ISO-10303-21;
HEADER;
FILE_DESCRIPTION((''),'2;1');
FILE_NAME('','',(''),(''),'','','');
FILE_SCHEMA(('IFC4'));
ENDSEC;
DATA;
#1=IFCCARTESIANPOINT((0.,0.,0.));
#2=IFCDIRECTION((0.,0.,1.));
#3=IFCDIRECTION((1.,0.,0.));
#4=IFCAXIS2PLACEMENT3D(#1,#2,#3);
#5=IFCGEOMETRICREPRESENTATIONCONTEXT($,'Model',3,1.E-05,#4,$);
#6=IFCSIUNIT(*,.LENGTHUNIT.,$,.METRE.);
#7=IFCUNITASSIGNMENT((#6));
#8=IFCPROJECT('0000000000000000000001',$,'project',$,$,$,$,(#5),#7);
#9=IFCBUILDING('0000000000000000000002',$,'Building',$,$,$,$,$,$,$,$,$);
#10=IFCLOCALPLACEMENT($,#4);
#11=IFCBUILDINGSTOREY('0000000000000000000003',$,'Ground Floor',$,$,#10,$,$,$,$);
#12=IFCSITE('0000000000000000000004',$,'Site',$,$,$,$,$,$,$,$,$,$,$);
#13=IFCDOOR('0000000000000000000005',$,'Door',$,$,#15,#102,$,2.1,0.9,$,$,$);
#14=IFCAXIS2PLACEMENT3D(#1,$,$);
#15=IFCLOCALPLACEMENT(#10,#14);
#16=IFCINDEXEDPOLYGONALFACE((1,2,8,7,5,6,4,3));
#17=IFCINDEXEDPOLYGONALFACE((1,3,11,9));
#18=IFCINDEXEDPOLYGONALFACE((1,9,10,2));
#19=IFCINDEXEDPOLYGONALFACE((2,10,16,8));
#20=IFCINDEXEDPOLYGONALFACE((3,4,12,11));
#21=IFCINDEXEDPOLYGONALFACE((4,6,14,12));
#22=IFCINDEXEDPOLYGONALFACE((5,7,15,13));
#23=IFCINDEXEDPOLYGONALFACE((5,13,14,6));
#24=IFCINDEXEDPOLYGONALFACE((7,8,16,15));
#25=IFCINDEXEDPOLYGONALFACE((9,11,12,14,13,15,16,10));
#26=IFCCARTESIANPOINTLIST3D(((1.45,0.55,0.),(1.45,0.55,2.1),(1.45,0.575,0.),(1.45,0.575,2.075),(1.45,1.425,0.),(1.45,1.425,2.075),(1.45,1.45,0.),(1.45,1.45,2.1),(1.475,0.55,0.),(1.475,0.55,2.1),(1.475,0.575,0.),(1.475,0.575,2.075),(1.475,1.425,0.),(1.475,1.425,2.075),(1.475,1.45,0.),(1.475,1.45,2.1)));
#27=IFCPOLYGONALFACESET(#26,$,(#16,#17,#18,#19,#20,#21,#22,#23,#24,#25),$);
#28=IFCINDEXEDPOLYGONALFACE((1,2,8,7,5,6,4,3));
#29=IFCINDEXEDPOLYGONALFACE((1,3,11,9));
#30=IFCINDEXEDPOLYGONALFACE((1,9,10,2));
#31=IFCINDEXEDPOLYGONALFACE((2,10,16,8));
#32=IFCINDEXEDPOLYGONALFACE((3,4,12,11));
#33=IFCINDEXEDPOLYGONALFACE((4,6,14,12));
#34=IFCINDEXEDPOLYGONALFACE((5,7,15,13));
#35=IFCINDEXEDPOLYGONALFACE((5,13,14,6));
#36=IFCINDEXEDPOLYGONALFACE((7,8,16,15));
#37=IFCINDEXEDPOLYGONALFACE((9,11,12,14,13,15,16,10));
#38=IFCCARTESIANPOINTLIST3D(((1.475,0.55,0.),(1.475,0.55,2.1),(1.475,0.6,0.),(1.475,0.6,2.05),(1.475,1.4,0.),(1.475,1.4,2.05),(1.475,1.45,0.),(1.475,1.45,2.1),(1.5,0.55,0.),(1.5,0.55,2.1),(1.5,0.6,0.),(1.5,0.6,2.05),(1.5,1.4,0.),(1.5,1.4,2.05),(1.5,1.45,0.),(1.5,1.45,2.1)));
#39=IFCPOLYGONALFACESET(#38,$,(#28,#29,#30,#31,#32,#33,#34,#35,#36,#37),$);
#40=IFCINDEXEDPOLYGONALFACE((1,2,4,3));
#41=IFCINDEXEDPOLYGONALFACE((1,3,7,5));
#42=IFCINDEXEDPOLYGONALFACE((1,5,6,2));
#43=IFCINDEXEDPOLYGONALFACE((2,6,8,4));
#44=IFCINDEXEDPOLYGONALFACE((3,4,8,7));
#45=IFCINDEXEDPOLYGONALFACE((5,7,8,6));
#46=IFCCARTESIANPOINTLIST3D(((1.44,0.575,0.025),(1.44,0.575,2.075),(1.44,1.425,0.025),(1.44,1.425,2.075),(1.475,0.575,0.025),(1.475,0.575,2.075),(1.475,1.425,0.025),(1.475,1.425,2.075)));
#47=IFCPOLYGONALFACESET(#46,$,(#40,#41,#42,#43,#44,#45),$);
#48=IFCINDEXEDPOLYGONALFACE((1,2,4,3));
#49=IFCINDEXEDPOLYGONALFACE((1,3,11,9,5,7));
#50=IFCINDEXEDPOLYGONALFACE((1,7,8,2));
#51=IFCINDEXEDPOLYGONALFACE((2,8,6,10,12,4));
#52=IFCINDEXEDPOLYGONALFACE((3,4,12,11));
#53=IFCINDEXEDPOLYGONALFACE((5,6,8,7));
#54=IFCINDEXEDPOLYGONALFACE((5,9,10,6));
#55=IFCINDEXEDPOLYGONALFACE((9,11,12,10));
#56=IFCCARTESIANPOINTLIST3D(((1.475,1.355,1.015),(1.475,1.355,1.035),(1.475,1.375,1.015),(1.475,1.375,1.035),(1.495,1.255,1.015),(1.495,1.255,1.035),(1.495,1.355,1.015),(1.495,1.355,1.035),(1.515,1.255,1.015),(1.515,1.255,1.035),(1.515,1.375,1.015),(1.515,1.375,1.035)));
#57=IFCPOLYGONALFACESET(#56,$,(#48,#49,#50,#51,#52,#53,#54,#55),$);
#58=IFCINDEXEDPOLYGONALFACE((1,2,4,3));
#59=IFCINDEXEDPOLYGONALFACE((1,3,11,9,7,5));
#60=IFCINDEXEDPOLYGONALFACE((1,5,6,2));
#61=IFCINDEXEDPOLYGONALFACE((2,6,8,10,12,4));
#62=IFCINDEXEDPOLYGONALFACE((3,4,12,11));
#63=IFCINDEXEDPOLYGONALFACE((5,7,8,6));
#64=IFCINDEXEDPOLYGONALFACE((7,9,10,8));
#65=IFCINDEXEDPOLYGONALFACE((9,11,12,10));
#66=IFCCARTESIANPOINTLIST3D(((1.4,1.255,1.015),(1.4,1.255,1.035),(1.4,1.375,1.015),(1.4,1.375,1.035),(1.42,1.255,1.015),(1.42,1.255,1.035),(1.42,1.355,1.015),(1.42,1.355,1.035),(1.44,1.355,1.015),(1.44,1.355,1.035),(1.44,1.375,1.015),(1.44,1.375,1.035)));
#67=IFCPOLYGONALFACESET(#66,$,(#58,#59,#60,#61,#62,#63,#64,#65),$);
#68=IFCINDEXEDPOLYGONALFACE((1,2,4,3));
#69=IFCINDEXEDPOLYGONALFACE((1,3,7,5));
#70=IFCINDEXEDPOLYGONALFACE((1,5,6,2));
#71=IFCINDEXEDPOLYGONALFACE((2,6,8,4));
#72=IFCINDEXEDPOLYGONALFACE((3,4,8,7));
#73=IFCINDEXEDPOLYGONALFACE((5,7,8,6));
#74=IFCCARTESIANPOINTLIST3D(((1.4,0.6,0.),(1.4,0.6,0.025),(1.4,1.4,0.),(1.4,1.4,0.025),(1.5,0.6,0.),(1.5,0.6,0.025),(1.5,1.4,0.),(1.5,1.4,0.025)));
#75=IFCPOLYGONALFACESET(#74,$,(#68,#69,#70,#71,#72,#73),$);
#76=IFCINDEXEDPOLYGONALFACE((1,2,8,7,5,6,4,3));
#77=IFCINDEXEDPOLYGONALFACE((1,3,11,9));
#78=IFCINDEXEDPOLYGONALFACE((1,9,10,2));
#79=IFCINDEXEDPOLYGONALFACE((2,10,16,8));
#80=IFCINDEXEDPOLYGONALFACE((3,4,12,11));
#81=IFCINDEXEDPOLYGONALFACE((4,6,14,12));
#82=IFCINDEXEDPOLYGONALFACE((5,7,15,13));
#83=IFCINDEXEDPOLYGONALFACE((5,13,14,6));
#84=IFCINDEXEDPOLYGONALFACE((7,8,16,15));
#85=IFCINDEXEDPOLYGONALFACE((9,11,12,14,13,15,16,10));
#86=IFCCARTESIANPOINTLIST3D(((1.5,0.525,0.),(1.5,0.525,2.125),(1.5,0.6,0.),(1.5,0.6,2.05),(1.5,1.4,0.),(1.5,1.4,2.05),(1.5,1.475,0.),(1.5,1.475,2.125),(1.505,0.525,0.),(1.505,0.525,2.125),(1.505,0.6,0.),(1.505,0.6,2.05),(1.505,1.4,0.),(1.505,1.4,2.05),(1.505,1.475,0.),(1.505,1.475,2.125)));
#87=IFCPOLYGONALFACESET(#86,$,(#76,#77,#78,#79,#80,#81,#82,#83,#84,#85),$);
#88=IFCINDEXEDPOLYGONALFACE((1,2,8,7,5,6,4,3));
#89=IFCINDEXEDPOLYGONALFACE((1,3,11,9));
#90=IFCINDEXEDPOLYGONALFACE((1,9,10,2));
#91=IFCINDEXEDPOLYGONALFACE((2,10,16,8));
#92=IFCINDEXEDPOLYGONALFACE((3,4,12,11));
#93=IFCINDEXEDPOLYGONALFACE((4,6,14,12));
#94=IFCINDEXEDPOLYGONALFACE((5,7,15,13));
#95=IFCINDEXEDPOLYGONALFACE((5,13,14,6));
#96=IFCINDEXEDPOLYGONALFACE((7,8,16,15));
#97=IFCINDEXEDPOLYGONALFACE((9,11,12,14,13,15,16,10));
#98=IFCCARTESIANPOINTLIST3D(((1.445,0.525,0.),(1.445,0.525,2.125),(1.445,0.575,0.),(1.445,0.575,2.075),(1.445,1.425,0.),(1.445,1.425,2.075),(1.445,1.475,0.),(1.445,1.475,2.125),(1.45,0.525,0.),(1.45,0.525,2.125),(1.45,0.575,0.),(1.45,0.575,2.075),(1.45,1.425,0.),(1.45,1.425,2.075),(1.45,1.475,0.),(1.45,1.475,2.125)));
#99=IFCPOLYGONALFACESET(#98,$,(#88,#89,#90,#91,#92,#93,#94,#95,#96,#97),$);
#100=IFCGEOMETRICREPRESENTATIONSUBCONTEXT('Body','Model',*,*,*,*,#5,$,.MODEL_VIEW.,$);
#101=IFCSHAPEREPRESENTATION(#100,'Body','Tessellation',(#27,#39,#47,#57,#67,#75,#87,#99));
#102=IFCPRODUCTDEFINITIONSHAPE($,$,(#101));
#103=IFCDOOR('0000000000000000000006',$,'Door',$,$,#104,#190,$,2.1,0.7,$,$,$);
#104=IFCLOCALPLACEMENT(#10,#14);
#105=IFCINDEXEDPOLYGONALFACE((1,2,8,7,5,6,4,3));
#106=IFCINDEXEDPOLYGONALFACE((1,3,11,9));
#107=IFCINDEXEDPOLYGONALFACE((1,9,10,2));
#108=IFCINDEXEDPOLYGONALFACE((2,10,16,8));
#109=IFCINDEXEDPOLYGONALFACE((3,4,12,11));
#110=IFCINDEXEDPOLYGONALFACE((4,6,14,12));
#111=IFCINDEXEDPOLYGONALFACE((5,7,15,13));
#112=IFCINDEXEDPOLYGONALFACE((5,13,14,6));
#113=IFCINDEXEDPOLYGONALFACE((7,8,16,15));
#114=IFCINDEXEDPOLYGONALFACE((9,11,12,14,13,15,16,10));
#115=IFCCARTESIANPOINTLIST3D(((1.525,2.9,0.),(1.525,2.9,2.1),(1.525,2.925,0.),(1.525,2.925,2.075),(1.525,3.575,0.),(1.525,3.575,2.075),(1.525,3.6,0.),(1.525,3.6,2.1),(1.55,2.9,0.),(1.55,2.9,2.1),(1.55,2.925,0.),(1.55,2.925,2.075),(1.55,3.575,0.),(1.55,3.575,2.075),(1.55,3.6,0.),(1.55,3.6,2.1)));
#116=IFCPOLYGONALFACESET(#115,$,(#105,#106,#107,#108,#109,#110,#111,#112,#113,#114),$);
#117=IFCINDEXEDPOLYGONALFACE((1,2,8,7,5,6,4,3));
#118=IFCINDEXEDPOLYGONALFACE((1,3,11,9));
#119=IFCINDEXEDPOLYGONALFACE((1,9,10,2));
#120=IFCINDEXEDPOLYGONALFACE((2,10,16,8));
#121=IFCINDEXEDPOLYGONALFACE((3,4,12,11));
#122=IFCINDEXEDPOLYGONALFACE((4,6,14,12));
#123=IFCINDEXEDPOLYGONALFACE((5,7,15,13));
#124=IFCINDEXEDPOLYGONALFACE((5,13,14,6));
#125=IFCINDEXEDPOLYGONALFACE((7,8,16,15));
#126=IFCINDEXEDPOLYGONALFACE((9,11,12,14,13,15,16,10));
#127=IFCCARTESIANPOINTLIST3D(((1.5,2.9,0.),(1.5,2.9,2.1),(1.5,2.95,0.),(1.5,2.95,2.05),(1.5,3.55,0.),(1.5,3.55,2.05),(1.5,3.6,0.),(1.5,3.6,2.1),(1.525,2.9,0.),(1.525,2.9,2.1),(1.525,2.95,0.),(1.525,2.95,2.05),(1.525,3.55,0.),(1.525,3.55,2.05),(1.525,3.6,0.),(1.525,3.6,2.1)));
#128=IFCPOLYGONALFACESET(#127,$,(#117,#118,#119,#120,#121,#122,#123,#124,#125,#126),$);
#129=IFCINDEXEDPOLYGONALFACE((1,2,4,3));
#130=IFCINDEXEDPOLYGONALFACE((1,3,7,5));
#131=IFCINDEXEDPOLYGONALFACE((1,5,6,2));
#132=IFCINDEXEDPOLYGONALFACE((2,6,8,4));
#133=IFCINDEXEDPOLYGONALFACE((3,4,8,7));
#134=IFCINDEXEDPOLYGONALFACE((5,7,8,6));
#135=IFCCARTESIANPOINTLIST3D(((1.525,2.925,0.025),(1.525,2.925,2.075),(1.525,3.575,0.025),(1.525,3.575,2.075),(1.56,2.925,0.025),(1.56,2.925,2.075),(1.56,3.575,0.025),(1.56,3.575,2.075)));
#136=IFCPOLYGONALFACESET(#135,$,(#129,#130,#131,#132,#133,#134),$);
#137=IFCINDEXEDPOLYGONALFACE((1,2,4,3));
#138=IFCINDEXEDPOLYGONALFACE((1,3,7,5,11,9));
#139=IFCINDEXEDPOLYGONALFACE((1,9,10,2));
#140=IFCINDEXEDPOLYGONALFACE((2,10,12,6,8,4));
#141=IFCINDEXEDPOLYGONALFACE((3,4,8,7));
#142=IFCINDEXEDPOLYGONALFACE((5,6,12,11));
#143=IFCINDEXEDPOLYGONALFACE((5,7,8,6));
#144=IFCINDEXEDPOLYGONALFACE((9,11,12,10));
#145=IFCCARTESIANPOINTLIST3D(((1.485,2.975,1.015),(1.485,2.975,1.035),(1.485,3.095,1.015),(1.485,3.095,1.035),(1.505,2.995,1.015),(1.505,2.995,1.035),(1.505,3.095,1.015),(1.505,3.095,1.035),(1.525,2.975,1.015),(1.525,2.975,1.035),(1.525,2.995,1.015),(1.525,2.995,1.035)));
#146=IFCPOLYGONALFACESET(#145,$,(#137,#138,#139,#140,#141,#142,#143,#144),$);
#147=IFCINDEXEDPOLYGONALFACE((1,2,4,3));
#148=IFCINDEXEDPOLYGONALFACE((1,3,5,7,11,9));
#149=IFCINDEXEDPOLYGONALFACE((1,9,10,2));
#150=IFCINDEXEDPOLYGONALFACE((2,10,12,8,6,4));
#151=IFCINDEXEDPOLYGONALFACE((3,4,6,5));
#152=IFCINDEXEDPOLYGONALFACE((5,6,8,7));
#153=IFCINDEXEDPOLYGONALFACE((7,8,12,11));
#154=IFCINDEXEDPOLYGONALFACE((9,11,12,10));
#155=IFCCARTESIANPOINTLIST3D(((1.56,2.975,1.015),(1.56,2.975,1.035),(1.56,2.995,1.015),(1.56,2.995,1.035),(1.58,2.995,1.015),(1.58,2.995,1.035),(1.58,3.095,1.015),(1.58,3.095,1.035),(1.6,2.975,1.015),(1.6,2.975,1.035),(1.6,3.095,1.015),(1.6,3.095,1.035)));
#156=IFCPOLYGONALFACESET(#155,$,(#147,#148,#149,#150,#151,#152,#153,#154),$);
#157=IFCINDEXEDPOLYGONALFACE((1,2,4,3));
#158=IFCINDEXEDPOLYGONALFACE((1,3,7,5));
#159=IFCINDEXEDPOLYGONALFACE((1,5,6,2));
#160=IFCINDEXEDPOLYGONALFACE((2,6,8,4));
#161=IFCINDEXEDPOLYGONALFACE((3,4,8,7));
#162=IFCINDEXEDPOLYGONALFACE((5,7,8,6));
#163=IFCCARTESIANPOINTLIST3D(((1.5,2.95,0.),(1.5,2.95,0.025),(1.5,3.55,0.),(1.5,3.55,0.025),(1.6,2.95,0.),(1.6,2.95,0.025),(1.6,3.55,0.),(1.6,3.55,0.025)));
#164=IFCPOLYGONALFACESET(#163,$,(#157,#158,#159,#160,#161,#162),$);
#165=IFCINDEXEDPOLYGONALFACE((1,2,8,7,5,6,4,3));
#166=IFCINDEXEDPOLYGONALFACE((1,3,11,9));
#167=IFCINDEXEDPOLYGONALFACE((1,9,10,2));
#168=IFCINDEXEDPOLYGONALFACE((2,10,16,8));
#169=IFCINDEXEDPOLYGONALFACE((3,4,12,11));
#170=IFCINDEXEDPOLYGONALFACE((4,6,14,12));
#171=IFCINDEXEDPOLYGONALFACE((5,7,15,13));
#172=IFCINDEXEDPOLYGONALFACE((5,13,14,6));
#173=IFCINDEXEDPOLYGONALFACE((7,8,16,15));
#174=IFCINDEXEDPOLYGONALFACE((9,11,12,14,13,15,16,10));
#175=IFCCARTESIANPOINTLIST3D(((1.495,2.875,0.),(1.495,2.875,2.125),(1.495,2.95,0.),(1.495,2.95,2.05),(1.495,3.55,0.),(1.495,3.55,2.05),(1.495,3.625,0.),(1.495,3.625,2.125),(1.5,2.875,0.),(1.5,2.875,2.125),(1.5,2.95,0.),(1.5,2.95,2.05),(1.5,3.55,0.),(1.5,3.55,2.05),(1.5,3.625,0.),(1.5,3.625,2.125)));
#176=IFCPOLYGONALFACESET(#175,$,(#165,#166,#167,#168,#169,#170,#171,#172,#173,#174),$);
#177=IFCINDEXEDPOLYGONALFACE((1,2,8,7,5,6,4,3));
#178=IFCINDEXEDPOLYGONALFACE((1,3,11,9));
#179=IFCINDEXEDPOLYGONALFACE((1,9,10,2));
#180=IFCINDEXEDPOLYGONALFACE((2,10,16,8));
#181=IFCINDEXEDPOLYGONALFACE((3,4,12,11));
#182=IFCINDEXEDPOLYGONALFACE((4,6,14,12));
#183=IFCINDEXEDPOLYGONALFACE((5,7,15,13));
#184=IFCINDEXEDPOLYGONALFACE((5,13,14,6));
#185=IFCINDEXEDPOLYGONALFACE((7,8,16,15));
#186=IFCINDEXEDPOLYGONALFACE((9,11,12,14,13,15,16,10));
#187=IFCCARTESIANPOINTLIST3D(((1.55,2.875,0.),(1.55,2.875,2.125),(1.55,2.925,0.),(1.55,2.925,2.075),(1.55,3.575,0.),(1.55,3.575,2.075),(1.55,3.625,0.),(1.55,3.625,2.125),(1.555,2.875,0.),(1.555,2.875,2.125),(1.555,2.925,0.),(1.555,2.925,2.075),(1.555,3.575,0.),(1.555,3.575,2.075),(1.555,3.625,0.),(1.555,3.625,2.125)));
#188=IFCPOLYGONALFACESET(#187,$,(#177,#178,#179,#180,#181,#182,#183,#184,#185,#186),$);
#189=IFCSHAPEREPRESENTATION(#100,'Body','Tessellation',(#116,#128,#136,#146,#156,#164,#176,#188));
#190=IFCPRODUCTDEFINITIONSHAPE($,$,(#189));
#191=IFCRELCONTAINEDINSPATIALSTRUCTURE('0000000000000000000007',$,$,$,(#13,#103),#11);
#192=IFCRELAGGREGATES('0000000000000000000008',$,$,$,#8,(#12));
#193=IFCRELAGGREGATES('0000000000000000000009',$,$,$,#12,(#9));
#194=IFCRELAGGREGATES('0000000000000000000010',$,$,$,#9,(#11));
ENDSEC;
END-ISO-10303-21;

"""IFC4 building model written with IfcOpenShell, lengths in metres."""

from ifc_helpers import new_model, si_unit, frame, origin_with_axes, place, context, subcontext, project, spatial, line, indexed_curve, outline, extrude, element, save


model = new_model("IFC4")

# Units and contexts
model_context = context("Model", 3, precision=1e-05, world=origin_with_axes())
body_context = subcontext(model_context, "Body", "Model", "MODEL_VIEW")
ifc_project = project(units=[si_unit("LENGTHUNIT", "METRE")], contexts=[model_context])

# Site, building, storey
site = spatial("IfcSite", under=ifc_project, Name="Site")
building = spatial("IfcBuilding", under=site, Name="Building")
storey_placement = place(None, origin_with_axes())
storey = spatial("IfcBuildingStorey", under=building, at=storey_placement, Name="Ground Floor")

# Doors
door_1_placement = place(storey_placement, frame((1.5, 0.55, 0.0), z_axis=(0.0, 0.0, 1.0), x_axis=(0.0, 1.0, 0.0)))
element("IfcDoor", 1, at=door_1_placement, inside=storey, Name="Door", OverallHeight=2.1, OverallWidth=0.9, context=body_context, shape_type="SweptSolid", body=[
    extrude(outline(indexed_curve([(0.0, 0.0), (0.0, 2.1), (0.9, 2.1), (0.9, 0.0), (0.875, 0.0), (0.875, 2.075), (0.025, 2.075), (0.025, 0.0)], segments=[line(1, 2, 3, 4, 5, 6, 7, 8, 1)])), frame((0.0, 0.025, 0.0), z_axis=(0.0, -1.0, 0.0), x_axis=(1.0, 0.0, 0.0)), (0.0, 0.0, -1.0), 0.025),
    extrude(outline(indexed_curve([(0.0, 0.0), (0.0, 2.1), (0.9, 2.1), (0.9, 0.0), (0.85, 0.0), (0.85, 2.05), (0.05, 2.05), (0.05, 0.0)], segments=[line(1, 2, 3, 4, 5, 6, 7, 8, 1)])), frame((0.0, 0.0, 0.0), z_axis=(0.0, -1.0, 0.0), x_axis=(1.0, 0.0, 0.0)), (0.0, 0.0, -1.0), 0.025),
    extrude(outline(indexed_curve([(0.0, 0.0), (0.85, 0.0), (0.85, 0.035), (0.0, 0.035)], segments=[line(1, 2, 3, 4, 1)])), frame((0.025, 0.025, 0.025), z_axis=(0.0, 0.0, 1.0), x_axis=(1.0, 0.0, 0.0)), (0.0, 0.0, 1.0), 2.05),
    extrude(outline(indexed_curve([(0.0, 0.0), (0.0, -0.04), (-0.12, -0.04), (-0.12, -0.02), (-0.02, -0.02), (-0.02, 0.0)], segments=[line(1, 2, 3, 4, 5, 6, 1)])), frame((0.825, 0.025, 1.015), z_axis=(0.0, 0.0, 1.0), x_axis=(1.0, 0.0, 0.0)), (0.0, 0.0, 1.0), 0.02),
    extrude(outline(indexed_curve([(0.0, 0.0), (0.0, 0.04), (-0.12, 0.04), (-0.12, 0.02), (-0.02, 0.02), (-0.02, 0.0)], segments=[line(1, 2, 3, 4, 5, 6, 1)])), frame((0.825, 0.06, 1.015), z_axis=(0.0, 0.0, 1.0), x_axis=(1.0, 0.0, 0.0)), (0.0, 0.0, 1.0), 0.02),
    extrude(outline(indexed_curve([(0.0, 0.0), (0.8, 0.0), (0.8, 0.1), (0.0, 0.1)], segments=[line(1, 2, 3, 4, 1)])), frame((0.05, 0.0, 0.0), z_axis=(0.0, 0.0, 1.0), x_axis=(1.0, 0.0, 0.0)), (0.0, 0.0, 1.0), 0.025),
    extrude(outline(indexed_curve([(0.0, 0.0), (0.0, 2.125), (0.95, 2.125), (0.95, 0.0), (0.875, 0.0), (0.875, 2.05), (0.075, 2.05), (0.075, 0.0)], segments=[line(1, 2, 3, 4, 5, 6, 7, 8, 1)])), frame((-0.025, -0.005, 0.0), z_axis=(0.0, -1.0, 0.0), x_axis=(1.0, 0.0, 0.0)), (0.0, 0.0, -1.0), 0.005),
    extrude(outline(indexed_curve([(0.0, 0.0), (0.0, 2.125), (0.95, 2.125), (0.95, 0.0), (0.9, 0.0), (0.9, 2.075), (0.05, 2.075), (0.05, 0.0)], segments=[line(1, 2, 3, 4, 5, 6, 7, 8, 1)])), frame((-0.025, 0.05, 0.0), z_axis=(0.0, -1.0, 0.0), x_axis=(1.0, 0.0, 0.0)), (0.0, 0.0, -1.0), 0.005),
])
door_2_placement = place(storey_placement, frame((1.5, 3.6, 0.0), z_axis=(0.0, 0.0, 1.0), x_axis=(0.0, -1.0, 0.0)))
element("IfcDoor", 2, at=door_2_placement, inside=storey, Name="Door", OverallHeight=2.1, OverallWidth=0.7, context=body_context, shape_type="SweptSolid", body=[
    extrude(outline(indexed_curve([(0.0, 0.0), (0.0, 2.1), (0.7, 2.1), (0.7, 0.0), (0.675, 0.0), (0.675, 2.075), (0.025, 2.075), (0.025, 0.0)], segments=[line(1, 2, 3, 4, 5, 6, 7, 8, 1)])), frame((0.0, 0.025, 0.0), z_axis=(0.0, -1.0, 0.0), x_axis=(1.0, 0.0, 0.0)), (0.0, 0.0, -1.0), 0.025),
    extrude(outline(indexed_curve([(0.0, 0.0), (0.0, 2.1), (0.7, 2.1), (0.7, 0.0), (0.65, 0.0), (0.65, 2.05), (0.05, 2.05), (0.05, 0.0)], segments=[line(1, 2, 3, 4, 5, 6, 7, 8, 1)])), frame((0.0, 0.0, 0.0), z_axis=(0.0, -1.0, 0.0), x_axis=(1.0, 0.0, 0.0)), (0.0, 0.0, -1.0), 0.025),
    extrude(outline(indexed_curve([(0.0, 0.0), (0.65, 0.0), (0.65, 0.035), (0.0, 0.035)], segments=[line(1, 2, 3, 4, 1)])), frame((0.025, 0.025, 0.025), z_axis=(0.0, 0.0, 1.0), x_axis=(1.0, 0.0, 0.0)), (0.0, 0.0, 1.0), 2.05),
    extrude(outline(indexed_curve([(0.0, 0.0), (0.0, -0.04), (-0.12, -0.04), (-0.12, -0.02), (-0.02, -0.02), (-0.02, 0.0)], segments=[line(1, 2, 3, 4, 5, 6, 1)])), frame((0.625, 0.025, 1.015), z_axis=(0.0, 0.0, 1.0), x_axis=(1.0, 0.0, 0.0)), (0.0, 0.0, 1.0), 0.02),
    extrude(outline(indexed_curve([(0.0, 0.0), (0.0, 0.04), (-0.12, 0.04), (-0.12, 0.02), (-0.02, 0.02), (-0.02, 0.0)], segments=[line(1, 2, 3, 4, 5, 6, 1)])), frame((0.625, 0.06, 1.015), z_axis=(0.0, 0.0, 1.0), x_axis=(1.0, 0.0, 0.0)), (0.0, 0.0, 1.0), 0.02),
    extrude(outline(indexed_curve([(0.0, 0.0), (0.6, 0.0), (0.6, 0.1), (0.0, 0.1)], segments=[line(1, 2, 3, 4, 1)])), frame((0.05, 0.0, 0.0), z_axis=(0.0, 0.0, 1.0), x_axis=(1.0, 0.0, 0.0)), (0.0, 0.0, 1.0), 0.025),
    extrude(outline(indexed_curve([(0.0, 0.0), (0.0, 2.125), (0.75, 2.125), (0.75, 0.0), (0.675, 0.0), (0.675, 2.05), (0.075, 2.05), (0.075, 0.0)], segments=[line(1, 2, 3, 4, 5, 6, 7, 8, 1)])), frame((-0.025, -0.005, 0.0), z_axis=(0.0, -1.0, 0.0), x_axis=(1.0, 0.0, 0.0)), (0.0, 0.0, -1.0), 0.005),
    extrude(outline(indexed_curve([(0.0, 0.0), (0.0, 2.125), (0.75, 2.125), (0.75, 0.0), (0.7, 0.0), (0.7, 2.075), (0.05, 2.075), (0.05, 0.0)], segments=[line(1, 2, 3, 4, 5, 6, 7, 8, 1)])), frame((-0.025, 0.05, 0.0), z_axis=(0.0, -1.0, 0.0), x_axis=(1.0, 0.0, 0.0)), (0.0, 0.0, -1.0), 0.005),
])

save(model, "model.ifc")
